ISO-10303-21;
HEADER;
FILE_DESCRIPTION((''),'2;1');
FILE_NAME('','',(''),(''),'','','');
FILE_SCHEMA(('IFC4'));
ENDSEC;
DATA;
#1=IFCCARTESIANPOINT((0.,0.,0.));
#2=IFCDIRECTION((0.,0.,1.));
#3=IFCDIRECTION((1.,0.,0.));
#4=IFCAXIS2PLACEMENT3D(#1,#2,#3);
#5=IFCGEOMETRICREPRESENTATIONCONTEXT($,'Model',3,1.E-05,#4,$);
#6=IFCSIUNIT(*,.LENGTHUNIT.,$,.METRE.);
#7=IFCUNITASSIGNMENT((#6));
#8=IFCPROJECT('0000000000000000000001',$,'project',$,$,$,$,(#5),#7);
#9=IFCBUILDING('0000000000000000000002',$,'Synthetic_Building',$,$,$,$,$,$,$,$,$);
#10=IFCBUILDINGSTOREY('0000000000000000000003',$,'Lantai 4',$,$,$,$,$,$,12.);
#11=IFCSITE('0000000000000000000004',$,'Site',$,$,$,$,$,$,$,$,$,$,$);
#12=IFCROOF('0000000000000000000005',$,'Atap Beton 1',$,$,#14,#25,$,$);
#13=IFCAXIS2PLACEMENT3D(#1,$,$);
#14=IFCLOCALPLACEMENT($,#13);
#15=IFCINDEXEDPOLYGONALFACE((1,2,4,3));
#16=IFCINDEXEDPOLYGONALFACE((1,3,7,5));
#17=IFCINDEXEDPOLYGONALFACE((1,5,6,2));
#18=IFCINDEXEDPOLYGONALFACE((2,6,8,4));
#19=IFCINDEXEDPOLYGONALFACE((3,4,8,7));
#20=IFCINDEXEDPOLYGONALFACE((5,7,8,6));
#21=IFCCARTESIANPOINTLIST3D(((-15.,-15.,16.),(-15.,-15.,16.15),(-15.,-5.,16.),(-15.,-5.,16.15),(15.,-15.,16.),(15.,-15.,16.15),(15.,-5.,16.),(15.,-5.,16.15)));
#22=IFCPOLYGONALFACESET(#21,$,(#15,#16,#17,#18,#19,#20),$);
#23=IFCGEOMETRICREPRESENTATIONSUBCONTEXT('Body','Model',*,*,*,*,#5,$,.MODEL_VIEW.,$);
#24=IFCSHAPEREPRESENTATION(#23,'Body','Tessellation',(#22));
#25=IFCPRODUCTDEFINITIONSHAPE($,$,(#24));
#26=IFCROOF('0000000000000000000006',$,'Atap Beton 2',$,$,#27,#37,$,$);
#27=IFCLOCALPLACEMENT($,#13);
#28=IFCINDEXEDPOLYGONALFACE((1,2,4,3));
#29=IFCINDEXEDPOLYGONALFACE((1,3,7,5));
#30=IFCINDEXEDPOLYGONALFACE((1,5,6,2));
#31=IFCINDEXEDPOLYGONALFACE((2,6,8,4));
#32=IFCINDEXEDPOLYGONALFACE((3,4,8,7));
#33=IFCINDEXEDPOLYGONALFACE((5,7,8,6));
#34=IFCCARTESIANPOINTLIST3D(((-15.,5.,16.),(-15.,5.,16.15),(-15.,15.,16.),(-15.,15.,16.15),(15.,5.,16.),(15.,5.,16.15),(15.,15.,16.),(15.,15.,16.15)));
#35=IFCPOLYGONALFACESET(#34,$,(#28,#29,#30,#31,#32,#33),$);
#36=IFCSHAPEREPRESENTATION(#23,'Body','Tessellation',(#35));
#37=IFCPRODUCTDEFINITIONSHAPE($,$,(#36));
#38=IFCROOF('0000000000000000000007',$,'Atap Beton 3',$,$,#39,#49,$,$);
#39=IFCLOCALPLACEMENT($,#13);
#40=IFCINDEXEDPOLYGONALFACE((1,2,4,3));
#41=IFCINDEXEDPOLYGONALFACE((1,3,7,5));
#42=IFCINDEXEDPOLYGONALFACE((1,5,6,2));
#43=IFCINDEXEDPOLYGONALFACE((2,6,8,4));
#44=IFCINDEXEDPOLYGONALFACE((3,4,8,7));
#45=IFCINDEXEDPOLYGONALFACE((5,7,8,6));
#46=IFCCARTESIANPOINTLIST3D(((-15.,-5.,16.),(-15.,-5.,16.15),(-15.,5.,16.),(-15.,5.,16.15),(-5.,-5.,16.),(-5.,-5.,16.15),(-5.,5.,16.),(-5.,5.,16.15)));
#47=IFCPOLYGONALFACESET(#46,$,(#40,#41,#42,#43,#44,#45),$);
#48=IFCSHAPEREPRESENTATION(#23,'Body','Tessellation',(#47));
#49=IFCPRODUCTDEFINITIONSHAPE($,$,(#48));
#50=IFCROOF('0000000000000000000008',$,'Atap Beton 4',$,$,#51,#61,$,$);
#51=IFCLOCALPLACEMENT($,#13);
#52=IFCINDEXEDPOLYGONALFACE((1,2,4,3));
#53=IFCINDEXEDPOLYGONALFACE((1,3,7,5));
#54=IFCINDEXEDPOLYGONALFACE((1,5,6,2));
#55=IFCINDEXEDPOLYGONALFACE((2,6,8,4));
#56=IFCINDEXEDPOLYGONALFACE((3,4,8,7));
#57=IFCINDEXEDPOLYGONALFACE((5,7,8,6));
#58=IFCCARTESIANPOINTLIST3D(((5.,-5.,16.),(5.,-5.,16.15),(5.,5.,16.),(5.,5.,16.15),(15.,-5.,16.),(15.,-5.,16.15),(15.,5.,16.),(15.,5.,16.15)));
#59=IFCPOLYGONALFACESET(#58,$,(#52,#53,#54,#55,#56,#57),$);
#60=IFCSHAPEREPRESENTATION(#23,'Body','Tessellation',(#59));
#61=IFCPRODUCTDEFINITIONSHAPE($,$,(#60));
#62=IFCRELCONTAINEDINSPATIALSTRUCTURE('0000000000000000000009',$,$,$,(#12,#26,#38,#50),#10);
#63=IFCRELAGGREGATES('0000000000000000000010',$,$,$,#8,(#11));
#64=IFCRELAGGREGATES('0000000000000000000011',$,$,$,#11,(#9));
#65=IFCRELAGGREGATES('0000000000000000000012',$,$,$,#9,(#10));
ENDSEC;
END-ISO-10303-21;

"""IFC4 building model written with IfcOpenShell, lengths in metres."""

from ifc_helpers import new_model, si_unit, frame, origin_with_axes, place, context, subcontext, project, spatial, polyline, outline, extrude, element, save


model = new_model("IFC4")

# Units and contexts
model_context = context("Model", 3, precision=1e-05, world=origin_with_axes())
body_context = subcontext(model_context, "Body", "Model", "MODEL_VIEW")
ifc_project = project(units=[si_unit("LENGTHUNIT", "METRE")], contexts=[model_context])

# Site, building, storey
site = spatial("IfcSite", under=ifc_project, Name="Site")
building = spatial("IfcBuilding", under=site, Name="Synthetic_Building")
storey = spatial("IfcBuildingStorey", under=building, Name="Lantai 4", Elevation=12.0)

# Roofs
roof_1_placement = place(None, origin_with_axes())
element("IfcRoof", 1, at=roof_1_placement, inside=storey, Name="Atap Beton 1", context=body_context, shape_type="SweptSolid", body=[
    extrude(outline(polyline([(-15.0, -15.0), (15.0, -15.0), (15.0, -5.0), (-15.0, -5.0), (-15.0, -15.0)])), frame((0.0, 0.0, 16.0), z_axis=(0.0, 0.0, 1.0), x_axis=(1.0, 0.0, 0.0)), (0.0, 0.0, 1.0), 0.15),
])
roof_2_placement = place(None, origin_with_axes())
element("IfcRoof", 2, at=roof_2_placement, inside=storey, Name="Atap Beton 2", context=body_context, shape_type="SweptSolid", body=[
    extrude(outline(polyline([(-15.0, 5.0), (15.0, 5.0), (15.0, 15.0), (-15.0, 15.0), (-15.0, 5.0)])), frame((0.0, 0.0, 16.0), z_axis=(0.0, 0.0, 1.0), x_axis=(1.0, 0.0, 0.0)), (0.0, 0.0, 1.0), 0.15),
])
roof_3_placement = place(None, origin_with_axes())
element("IfcRoof", 3, at=roof_3_placement, inside=storey, Name="Atap Beton 3", context=body_context, shape_type="SweptSolid", body=[
    extrude(outline(polyline([(-15.0, -5.0), (-5.0, -5.0), (-5.0, 5.0), (-15.0, 5.0), (-15.0, -5.0)])), frame((0.0, 0.0, 16.0), z_axis=(0.0, 0.0, 1.0), x_axis=(1.0, 0.0, 0.0)), (0.0, 0.0, 1.0), 0.15),
])
roof_4_placement = place(None, origin_with_axes())
element("IfcRoof", 4, at=roof_4_placement, inside=storey, Name="Atap Beton 4", context=body_context, shape_type="SweptSolid", body=[
    extrude(outline(polyline([(5.0, -5.0), (15.0, -5.0), (15.0, 5.0), (5.0, 5.0), (5.0, -5.0)])), frame((0.0, 0.0, 16.0), z_axis=(0.0, 0.0, 1.0), x_axis=(1.0, 0.0, 0.0)), (0.0, 0.0, 1.0), 0.15),
])

save(model, "model.ifc")
